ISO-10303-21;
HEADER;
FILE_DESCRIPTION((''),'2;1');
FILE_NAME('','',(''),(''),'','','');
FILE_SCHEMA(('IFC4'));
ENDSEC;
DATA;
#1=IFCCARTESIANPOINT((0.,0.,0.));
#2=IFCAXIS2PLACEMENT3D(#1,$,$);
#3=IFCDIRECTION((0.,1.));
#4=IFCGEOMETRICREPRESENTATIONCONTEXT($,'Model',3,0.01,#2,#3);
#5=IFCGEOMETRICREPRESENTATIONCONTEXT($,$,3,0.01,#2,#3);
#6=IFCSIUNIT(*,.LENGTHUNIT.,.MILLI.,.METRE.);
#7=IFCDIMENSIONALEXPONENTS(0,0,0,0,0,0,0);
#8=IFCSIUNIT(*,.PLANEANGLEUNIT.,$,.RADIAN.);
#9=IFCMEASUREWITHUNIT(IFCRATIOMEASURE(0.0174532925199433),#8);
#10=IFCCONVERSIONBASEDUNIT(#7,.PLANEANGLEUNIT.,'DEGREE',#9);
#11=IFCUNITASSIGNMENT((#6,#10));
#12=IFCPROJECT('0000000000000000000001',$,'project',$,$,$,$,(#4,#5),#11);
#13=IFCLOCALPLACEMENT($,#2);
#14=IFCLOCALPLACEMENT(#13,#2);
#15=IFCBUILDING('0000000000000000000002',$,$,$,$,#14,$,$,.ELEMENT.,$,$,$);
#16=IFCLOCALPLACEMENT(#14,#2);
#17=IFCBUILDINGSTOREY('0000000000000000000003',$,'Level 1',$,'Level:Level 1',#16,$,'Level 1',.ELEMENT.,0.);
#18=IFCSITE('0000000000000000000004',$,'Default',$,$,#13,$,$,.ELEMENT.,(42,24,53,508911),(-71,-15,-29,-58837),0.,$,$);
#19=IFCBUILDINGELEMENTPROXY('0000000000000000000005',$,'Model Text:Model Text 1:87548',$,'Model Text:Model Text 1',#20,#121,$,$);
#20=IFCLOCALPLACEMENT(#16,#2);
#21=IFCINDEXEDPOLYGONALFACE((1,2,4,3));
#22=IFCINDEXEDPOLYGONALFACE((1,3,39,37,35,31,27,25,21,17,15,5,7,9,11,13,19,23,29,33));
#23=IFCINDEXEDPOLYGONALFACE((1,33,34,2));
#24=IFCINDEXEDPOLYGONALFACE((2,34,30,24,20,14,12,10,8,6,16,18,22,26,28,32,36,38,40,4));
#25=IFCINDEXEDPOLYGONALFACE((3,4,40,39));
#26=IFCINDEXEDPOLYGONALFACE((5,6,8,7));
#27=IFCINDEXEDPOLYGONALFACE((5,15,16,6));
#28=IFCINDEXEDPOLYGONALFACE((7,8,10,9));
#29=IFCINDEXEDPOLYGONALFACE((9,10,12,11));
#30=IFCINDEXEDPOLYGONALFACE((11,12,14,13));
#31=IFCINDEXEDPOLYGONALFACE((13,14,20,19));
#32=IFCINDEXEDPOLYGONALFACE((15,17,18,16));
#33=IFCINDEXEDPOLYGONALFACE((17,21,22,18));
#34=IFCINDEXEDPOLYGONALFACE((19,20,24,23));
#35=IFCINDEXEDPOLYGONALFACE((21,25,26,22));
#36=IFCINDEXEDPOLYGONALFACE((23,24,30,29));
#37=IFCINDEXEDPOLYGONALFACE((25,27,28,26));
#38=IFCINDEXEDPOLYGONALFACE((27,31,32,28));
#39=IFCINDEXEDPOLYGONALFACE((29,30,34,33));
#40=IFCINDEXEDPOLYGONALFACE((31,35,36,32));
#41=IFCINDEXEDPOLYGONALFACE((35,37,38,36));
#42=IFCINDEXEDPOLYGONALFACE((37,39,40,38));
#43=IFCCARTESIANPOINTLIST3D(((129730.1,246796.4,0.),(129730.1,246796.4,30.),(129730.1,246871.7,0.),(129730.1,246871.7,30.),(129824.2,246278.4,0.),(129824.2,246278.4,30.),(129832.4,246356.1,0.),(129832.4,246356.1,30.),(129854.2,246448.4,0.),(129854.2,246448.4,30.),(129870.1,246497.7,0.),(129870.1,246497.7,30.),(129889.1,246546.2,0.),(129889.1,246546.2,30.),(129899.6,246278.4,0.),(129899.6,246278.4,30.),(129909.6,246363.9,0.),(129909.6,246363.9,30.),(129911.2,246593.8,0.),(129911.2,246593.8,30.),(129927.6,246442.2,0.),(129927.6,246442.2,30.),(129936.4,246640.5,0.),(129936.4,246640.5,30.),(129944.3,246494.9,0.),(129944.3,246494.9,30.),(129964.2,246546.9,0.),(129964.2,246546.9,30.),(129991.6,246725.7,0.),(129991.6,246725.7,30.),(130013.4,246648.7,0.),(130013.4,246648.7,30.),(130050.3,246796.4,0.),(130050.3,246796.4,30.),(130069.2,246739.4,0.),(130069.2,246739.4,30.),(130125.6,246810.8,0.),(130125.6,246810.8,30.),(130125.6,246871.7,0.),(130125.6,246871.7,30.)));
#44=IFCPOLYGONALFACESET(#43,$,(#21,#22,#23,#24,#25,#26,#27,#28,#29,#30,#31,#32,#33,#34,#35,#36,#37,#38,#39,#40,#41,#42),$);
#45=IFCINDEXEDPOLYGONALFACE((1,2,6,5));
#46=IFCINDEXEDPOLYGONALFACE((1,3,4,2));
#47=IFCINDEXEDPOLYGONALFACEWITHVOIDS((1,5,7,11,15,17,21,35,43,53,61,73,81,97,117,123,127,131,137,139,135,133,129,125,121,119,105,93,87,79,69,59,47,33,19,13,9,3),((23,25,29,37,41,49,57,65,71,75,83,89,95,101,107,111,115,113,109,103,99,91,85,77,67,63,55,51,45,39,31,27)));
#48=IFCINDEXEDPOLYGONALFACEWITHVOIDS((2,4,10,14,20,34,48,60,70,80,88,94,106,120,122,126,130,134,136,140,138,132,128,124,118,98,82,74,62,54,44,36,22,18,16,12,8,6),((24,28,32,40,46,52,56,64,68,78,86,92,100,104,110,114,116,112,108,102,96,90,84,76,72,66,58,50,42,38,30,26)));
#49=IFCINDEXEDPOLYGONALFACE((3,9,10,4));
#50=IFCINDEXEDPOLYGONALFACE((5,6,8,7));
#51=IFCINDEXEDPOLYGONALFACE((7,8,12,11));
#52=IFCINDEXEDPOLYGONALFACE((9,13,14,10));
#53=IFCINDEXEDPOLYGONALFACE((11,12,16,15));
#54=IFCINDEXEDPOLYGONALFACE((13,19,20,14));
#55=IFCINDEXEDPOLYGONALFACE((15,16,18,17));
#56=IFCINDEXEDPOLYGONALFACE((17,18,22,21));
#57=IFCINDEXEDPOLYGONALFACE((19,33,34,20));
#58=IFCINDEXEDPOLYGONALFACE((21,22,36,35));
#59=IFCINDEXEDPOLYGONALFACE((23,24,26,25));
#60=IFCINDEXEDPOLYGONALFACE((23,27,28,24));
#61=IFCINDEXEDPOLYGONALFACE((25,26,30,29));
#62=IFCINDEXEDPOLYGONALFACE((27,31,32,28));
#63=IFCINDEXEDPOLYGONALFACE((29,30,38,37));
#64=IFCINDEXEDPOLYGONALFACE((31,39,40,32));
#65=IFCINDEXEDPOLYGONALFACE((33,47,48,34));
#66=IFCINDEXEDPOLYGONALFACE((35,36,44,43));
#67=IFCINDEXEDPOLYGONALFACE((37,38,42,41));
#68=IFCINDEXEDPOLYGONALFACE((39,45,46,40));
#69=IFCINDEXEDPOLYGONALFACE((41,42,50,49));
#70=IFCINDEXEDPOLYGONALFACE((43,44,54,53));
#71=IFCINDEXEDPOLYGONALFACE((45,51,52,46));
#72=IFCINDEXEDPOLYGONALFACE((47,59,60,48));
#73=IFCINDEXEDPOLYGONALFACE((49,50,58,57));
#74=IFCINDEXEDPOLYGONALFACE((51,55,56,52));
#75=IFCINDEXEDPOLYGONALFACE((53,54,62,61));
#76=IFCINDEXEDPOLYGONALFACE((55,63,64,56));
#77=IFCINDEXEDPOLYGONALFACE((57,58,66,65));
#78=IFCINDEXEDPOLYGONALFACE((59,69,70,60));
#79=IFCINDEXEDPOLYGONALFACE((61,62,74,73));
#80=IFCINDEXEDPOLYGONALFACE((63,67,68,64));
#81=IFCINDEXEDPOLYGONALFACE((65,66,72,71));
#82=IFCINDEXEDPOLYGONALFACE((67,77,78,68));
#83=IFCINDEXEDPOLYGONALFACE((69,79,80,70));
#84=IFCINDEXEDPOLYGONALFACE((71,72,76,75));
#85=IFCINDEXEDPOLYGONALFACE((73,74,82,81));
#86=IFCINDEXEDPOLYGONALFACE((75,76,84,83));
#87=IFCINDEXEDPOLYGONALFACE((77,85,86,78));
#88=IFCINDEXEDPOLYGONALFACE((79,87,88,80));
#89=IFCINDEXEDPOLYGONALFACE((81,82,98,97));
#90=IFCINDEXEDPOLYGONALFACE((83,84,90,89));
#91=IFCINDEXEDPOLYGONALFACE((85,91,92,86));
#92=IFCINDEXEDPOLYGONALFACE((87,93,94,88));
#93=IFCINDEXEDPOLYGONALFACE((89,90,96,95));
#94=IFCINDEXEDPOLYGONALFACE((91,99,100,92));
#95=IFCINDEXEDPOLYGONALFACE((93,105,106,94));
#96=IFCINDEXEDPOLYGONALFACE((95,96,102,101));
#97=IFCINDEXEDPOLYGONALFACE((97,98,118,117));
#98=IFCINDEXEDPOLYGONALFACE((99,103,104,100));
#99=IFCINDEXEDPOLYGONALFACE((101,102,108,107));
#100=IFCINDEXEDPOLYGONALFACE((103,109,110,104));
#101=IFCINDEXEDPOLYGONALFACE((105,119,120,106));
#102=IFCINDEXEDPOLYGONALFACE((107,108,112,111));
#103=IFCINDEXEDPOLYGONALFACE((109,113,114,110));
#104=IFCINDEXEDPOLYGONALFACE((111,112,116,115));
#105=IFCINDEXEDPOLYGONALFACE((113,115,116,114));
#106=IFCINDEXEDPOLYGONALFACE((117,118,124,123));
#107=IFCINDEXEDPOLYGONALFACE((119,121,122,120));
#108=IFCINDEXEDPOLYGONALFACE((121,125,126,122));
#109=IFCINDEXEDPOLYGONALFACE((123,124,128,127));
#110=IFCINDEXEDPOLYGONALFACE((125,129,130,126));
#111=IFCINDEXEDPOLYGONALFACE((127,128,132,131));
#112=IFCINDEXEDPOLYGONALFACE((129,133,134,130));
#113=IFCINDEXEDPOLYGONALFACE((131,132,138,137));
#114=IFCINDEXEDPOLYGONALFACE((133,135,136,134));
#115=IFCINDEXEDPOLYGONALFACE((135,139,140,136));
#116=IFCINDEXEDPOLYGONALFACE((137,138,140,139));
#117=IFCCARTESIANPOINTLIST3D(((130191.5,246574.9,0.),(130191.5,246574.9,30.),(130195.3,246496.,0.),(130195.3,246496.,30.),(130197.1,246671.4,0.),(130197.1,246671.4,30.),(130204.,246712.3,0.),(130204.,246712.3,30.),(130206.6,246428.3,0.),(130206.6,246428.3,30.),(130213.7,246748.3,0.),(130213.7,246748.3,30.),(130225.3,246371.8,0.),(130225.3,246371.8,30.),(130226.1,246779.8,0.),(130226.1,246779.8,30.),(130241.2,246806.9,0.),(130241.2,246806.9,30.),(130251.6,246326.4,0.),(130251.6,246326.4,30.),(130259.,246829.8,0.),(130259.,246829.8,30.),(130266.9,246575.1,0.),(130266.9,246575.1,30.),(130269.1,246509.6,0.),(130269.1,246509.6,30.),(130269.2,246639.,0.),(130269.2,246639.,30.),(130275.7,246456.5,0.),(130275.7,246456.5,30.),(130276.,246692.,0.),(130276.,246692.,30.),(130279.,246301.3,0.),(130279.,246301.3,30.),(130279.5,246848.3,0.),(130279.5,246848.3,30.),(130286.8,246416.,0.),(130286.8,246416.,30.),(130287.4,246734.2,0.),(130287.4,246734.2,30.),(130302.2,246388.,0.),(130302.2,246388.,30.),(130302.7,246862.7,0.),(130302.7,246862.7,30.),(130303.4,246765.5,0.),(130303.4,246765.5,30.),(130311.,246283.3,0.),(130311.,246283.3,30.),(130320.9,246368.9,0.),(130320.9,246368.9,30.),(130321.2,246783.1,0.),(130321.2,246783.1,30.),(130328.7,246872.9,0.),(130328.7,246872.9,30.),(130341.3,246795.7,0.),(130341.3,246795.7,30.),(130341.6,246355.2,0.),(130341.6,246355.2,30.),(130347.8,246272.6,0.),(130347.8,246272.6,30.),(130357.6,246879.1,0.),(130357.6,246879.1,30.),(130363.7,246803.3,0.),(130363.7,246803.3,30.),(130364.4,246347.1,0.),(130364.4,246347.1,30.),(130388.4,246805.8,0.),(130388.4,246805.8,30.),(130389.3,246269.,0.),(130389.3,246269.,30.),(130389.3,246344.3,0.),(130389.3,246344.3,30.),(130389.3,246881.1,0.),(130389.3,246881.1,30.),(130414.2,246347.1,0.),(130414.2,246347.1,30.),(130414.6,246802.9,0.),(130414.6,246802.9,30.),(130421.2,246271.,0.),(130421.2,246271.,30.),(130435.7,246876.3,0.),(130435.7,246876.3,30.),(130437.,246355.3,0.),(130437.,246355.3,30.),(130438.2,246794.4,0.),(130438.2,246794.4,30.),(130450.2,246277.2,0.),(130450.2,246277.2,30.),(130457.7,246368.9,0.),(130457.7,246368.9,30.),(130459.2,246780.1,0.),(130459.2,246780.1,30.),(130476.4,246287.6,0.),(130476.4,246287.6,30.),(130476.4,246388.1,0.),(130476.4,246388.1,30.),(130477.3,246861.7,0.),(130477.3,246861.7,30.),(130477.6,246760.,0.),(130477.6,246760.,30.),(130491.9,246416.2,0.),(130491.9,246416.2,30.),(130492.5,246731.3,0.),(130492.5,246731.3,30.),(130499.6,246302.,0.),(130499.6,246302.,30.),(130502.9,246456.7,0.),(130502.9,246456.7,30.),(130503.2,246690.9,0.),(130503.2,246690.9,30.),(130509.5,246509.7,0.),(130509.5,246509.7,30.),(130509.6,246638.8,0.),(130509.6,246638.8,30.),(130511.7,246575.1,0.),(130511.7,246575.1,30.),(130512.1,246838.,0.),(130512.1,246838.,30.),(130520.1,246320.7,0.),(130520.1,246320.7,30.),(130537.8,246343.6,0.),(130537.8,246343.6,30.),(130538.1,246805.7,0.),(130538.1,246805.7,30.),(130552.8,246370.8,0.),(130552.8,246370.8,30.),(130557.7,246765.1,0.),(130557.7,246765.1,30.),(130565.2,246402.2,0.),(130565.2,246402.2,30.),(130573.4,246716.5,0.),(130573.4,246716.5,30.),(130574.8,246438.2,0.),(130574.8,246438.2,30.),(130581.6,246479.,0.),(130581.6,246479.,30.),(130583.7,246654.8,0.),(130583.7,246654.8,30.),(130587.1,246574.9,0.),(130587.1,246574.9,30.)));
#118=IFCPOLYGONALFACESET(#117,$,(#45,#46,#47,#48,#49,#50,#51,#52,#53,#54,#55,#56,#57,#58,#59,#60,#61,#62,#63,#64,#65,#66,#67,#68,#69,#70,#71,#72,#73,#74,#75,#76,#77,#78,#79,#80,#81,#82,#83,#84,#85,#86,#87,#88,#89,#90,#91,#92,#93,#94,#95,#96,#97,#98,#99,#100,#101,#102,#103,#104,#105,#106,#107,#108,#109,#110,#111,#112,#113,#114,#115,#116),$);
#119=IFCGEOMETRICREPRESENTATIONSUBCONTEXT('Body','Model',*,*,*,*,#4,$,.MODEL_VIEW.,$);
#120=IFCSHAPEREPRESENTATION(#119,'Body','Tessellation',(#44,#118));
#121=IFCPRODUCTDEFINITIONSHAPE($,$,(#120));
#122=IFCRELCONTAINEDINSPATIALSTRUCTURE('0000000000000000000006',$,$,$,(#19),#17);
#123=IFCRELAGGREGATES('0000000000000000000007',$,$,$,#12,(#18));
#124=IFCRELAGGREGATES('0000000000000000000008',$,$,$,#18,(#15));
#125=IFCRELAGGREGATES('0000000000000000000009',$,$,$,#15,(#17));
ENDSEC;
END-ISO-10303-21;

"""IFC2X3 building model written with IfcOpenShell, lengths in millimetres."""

from ifc_helpers import new_model, entity, si_unit, converted_unit, direction, frame, origin, place, context, subcontext, project, spatial, polyline, outline, extrude, element, save


model = new_model("IFC2X3")

# Units and contexts
model_context = context("Model", 3, precision=0.01, world=origin(), true_north=direction((0.0, 1.0)))
context_of_model = context(None, 3, precision=0.01, world=origin(), true_north=direction((0.0, 1.0)))
body_context = subcontext(model_context, "Body", "Model", "MODEL_VIEW")
ifc_project = project(units=[si_unit("LENGTHUNIT", "METRE", prefix="MILLI"), converted_unit("PLANEANGLEUNIT", "DEGREE", entity("IfcRatioMeasure", 0.0174532925199433), si_unit("PLANEANGLEUNIT", "RADIAN"), dimensions=[0, 0, 0, 0, 0, 0, 0])], contexts=[model_context, context_of_model])

# Site, building, storey
site_placement = place(None, origin())
site = spatial("IfcSite", under=ifc_project, at=site_placement, Name="Default", CompositionType="ELEMENT", RefLatitude=(42, 24, 53, 508911), RefLongitude=(-71, -15, -29, -58837), RefElevation=0.0)
building_placement = place(site_placement, origin())
building = spatial("IfcBuilding", under=site, at=building_placement, CompositionType="ELEMENT")
storey_placement = place(building_placement, origin())
storey = spatial("IfcBuildingStorey", under=building, at=storey_placement, Name="Level 1", ObjectType="Level:Level 1", LongName="Level 1", CompositionType="ELEMENT", Elevation=0.0)

# Building element proxy
proxy_1_placement = place(storey_placement, origin())
element("IfcBuildingElementProxy", 1, at=proxy_1_placement, inside=storey, Name="Model Text:Model Text 1:87548", ObjectType="Model Text:Model Text 1", context=body_context, shape_type="SweptSolid", body=[
    extrude(outline(polyline([(-199.9, -209.0), (-199.9, -284.3), (195.7, -284.3), (195.7, -223.4), (139.3, -152.0), (83.5, -61.3), (34.2, 40.5), (14.4, 92.5), (-2.4, 145.2), (-20.3, 223.5), (-30.3, 309.0), (-105.7, 309.0), (-97.5, 231.3), (-75.7, 139.0), (-59.9, 89.7), (-40.9, 41.2), (-18.8, -6.4), (6.4, -53.1), (61.7, -138.3), (120.3, -209.0), (-199.9, -209.0)])), frame((129929.9, 246587.4, 0.0), z_axis=(0.0, 0.0, -1.0), x_axis=(1.0, 0.0, 0.0)), (0.0, 0.0, -1.0), 30.0),
    extrude(outline(polyline([(-10.6, -198.7), (68.3, -198.7), (136.5, -190.7), (193.9, -174.7), (240.5, -150.6), (266.9, -124.4), (286.3, -93.2), (298.8, -57.0), (304.3, -15.7), (303.8, 16.2), (299.0, 45.5), (289.9, 72.1), (276.6, 96.0), (258.9, 117.3), (236.9, 136.2), (210.4, 152.5), (179.6, 166.3), (144.1, 177.6), (103.7, 186.3), (8.2, 196.4), (-71.8, 196.7), (-134.0, 189.4), (-183.3, 176.1), (-224.7, 158.4), (-258.2, 133.9), (-283.5, 100.3), (-300.1, 59.5), (-307.1, 13.4), (-306.6, -18.4), (-301.8, -47.5), (-292.8, -74.0), (-279.6, -97.9), (-262.0, -119.2), (-240.0, -138.1), (-213.6, -154.5), (-182.8, -168.4), (-147.3, -179.8), (-106.7, -188.6), (-10.6, -198.7)]), holes=[polyline([(-7.2, -123.5), (-71.0, -118.2), (-123.6, -108.8), (-165.2, -95.4), (-195.7, -78.0), (-212.4, -59.4), (-224.1, -38.7), (-230.6, -15.9), (-231.9, 8.9), (-227.8, 35.0), (-218.1, 58.1), (-202.8, 78.4), (-182.0, 95.8), (-152.6, 109.4), (-111.7, 118.1), (-59.4, 122.0), (4.4, 121.1), (69.6, 115.8), (122.2, 106.7), (162.2, 93.7), (189.5, 77.0), (207.7, 57.4), (220.4, 36.0), (227.5, 12.8), (229.1, -12.1), (225.2, -36.8), (215.9, -59.2), (201.3, -79.3), (181.4, -97.1), (152.6, -111.2), (111.6, -120.3), (58.3, -124.4), (-7.2, -123.5)])]), frame((130390.6, 246573.7, 0.0), z_axis=(0.0, 0.0, 1.0), x_axis=(0.047515, -0.998871, 0.0)), (0.0, 0.0, 1.0), 30.0),
])

save(model, "model.ifc")
